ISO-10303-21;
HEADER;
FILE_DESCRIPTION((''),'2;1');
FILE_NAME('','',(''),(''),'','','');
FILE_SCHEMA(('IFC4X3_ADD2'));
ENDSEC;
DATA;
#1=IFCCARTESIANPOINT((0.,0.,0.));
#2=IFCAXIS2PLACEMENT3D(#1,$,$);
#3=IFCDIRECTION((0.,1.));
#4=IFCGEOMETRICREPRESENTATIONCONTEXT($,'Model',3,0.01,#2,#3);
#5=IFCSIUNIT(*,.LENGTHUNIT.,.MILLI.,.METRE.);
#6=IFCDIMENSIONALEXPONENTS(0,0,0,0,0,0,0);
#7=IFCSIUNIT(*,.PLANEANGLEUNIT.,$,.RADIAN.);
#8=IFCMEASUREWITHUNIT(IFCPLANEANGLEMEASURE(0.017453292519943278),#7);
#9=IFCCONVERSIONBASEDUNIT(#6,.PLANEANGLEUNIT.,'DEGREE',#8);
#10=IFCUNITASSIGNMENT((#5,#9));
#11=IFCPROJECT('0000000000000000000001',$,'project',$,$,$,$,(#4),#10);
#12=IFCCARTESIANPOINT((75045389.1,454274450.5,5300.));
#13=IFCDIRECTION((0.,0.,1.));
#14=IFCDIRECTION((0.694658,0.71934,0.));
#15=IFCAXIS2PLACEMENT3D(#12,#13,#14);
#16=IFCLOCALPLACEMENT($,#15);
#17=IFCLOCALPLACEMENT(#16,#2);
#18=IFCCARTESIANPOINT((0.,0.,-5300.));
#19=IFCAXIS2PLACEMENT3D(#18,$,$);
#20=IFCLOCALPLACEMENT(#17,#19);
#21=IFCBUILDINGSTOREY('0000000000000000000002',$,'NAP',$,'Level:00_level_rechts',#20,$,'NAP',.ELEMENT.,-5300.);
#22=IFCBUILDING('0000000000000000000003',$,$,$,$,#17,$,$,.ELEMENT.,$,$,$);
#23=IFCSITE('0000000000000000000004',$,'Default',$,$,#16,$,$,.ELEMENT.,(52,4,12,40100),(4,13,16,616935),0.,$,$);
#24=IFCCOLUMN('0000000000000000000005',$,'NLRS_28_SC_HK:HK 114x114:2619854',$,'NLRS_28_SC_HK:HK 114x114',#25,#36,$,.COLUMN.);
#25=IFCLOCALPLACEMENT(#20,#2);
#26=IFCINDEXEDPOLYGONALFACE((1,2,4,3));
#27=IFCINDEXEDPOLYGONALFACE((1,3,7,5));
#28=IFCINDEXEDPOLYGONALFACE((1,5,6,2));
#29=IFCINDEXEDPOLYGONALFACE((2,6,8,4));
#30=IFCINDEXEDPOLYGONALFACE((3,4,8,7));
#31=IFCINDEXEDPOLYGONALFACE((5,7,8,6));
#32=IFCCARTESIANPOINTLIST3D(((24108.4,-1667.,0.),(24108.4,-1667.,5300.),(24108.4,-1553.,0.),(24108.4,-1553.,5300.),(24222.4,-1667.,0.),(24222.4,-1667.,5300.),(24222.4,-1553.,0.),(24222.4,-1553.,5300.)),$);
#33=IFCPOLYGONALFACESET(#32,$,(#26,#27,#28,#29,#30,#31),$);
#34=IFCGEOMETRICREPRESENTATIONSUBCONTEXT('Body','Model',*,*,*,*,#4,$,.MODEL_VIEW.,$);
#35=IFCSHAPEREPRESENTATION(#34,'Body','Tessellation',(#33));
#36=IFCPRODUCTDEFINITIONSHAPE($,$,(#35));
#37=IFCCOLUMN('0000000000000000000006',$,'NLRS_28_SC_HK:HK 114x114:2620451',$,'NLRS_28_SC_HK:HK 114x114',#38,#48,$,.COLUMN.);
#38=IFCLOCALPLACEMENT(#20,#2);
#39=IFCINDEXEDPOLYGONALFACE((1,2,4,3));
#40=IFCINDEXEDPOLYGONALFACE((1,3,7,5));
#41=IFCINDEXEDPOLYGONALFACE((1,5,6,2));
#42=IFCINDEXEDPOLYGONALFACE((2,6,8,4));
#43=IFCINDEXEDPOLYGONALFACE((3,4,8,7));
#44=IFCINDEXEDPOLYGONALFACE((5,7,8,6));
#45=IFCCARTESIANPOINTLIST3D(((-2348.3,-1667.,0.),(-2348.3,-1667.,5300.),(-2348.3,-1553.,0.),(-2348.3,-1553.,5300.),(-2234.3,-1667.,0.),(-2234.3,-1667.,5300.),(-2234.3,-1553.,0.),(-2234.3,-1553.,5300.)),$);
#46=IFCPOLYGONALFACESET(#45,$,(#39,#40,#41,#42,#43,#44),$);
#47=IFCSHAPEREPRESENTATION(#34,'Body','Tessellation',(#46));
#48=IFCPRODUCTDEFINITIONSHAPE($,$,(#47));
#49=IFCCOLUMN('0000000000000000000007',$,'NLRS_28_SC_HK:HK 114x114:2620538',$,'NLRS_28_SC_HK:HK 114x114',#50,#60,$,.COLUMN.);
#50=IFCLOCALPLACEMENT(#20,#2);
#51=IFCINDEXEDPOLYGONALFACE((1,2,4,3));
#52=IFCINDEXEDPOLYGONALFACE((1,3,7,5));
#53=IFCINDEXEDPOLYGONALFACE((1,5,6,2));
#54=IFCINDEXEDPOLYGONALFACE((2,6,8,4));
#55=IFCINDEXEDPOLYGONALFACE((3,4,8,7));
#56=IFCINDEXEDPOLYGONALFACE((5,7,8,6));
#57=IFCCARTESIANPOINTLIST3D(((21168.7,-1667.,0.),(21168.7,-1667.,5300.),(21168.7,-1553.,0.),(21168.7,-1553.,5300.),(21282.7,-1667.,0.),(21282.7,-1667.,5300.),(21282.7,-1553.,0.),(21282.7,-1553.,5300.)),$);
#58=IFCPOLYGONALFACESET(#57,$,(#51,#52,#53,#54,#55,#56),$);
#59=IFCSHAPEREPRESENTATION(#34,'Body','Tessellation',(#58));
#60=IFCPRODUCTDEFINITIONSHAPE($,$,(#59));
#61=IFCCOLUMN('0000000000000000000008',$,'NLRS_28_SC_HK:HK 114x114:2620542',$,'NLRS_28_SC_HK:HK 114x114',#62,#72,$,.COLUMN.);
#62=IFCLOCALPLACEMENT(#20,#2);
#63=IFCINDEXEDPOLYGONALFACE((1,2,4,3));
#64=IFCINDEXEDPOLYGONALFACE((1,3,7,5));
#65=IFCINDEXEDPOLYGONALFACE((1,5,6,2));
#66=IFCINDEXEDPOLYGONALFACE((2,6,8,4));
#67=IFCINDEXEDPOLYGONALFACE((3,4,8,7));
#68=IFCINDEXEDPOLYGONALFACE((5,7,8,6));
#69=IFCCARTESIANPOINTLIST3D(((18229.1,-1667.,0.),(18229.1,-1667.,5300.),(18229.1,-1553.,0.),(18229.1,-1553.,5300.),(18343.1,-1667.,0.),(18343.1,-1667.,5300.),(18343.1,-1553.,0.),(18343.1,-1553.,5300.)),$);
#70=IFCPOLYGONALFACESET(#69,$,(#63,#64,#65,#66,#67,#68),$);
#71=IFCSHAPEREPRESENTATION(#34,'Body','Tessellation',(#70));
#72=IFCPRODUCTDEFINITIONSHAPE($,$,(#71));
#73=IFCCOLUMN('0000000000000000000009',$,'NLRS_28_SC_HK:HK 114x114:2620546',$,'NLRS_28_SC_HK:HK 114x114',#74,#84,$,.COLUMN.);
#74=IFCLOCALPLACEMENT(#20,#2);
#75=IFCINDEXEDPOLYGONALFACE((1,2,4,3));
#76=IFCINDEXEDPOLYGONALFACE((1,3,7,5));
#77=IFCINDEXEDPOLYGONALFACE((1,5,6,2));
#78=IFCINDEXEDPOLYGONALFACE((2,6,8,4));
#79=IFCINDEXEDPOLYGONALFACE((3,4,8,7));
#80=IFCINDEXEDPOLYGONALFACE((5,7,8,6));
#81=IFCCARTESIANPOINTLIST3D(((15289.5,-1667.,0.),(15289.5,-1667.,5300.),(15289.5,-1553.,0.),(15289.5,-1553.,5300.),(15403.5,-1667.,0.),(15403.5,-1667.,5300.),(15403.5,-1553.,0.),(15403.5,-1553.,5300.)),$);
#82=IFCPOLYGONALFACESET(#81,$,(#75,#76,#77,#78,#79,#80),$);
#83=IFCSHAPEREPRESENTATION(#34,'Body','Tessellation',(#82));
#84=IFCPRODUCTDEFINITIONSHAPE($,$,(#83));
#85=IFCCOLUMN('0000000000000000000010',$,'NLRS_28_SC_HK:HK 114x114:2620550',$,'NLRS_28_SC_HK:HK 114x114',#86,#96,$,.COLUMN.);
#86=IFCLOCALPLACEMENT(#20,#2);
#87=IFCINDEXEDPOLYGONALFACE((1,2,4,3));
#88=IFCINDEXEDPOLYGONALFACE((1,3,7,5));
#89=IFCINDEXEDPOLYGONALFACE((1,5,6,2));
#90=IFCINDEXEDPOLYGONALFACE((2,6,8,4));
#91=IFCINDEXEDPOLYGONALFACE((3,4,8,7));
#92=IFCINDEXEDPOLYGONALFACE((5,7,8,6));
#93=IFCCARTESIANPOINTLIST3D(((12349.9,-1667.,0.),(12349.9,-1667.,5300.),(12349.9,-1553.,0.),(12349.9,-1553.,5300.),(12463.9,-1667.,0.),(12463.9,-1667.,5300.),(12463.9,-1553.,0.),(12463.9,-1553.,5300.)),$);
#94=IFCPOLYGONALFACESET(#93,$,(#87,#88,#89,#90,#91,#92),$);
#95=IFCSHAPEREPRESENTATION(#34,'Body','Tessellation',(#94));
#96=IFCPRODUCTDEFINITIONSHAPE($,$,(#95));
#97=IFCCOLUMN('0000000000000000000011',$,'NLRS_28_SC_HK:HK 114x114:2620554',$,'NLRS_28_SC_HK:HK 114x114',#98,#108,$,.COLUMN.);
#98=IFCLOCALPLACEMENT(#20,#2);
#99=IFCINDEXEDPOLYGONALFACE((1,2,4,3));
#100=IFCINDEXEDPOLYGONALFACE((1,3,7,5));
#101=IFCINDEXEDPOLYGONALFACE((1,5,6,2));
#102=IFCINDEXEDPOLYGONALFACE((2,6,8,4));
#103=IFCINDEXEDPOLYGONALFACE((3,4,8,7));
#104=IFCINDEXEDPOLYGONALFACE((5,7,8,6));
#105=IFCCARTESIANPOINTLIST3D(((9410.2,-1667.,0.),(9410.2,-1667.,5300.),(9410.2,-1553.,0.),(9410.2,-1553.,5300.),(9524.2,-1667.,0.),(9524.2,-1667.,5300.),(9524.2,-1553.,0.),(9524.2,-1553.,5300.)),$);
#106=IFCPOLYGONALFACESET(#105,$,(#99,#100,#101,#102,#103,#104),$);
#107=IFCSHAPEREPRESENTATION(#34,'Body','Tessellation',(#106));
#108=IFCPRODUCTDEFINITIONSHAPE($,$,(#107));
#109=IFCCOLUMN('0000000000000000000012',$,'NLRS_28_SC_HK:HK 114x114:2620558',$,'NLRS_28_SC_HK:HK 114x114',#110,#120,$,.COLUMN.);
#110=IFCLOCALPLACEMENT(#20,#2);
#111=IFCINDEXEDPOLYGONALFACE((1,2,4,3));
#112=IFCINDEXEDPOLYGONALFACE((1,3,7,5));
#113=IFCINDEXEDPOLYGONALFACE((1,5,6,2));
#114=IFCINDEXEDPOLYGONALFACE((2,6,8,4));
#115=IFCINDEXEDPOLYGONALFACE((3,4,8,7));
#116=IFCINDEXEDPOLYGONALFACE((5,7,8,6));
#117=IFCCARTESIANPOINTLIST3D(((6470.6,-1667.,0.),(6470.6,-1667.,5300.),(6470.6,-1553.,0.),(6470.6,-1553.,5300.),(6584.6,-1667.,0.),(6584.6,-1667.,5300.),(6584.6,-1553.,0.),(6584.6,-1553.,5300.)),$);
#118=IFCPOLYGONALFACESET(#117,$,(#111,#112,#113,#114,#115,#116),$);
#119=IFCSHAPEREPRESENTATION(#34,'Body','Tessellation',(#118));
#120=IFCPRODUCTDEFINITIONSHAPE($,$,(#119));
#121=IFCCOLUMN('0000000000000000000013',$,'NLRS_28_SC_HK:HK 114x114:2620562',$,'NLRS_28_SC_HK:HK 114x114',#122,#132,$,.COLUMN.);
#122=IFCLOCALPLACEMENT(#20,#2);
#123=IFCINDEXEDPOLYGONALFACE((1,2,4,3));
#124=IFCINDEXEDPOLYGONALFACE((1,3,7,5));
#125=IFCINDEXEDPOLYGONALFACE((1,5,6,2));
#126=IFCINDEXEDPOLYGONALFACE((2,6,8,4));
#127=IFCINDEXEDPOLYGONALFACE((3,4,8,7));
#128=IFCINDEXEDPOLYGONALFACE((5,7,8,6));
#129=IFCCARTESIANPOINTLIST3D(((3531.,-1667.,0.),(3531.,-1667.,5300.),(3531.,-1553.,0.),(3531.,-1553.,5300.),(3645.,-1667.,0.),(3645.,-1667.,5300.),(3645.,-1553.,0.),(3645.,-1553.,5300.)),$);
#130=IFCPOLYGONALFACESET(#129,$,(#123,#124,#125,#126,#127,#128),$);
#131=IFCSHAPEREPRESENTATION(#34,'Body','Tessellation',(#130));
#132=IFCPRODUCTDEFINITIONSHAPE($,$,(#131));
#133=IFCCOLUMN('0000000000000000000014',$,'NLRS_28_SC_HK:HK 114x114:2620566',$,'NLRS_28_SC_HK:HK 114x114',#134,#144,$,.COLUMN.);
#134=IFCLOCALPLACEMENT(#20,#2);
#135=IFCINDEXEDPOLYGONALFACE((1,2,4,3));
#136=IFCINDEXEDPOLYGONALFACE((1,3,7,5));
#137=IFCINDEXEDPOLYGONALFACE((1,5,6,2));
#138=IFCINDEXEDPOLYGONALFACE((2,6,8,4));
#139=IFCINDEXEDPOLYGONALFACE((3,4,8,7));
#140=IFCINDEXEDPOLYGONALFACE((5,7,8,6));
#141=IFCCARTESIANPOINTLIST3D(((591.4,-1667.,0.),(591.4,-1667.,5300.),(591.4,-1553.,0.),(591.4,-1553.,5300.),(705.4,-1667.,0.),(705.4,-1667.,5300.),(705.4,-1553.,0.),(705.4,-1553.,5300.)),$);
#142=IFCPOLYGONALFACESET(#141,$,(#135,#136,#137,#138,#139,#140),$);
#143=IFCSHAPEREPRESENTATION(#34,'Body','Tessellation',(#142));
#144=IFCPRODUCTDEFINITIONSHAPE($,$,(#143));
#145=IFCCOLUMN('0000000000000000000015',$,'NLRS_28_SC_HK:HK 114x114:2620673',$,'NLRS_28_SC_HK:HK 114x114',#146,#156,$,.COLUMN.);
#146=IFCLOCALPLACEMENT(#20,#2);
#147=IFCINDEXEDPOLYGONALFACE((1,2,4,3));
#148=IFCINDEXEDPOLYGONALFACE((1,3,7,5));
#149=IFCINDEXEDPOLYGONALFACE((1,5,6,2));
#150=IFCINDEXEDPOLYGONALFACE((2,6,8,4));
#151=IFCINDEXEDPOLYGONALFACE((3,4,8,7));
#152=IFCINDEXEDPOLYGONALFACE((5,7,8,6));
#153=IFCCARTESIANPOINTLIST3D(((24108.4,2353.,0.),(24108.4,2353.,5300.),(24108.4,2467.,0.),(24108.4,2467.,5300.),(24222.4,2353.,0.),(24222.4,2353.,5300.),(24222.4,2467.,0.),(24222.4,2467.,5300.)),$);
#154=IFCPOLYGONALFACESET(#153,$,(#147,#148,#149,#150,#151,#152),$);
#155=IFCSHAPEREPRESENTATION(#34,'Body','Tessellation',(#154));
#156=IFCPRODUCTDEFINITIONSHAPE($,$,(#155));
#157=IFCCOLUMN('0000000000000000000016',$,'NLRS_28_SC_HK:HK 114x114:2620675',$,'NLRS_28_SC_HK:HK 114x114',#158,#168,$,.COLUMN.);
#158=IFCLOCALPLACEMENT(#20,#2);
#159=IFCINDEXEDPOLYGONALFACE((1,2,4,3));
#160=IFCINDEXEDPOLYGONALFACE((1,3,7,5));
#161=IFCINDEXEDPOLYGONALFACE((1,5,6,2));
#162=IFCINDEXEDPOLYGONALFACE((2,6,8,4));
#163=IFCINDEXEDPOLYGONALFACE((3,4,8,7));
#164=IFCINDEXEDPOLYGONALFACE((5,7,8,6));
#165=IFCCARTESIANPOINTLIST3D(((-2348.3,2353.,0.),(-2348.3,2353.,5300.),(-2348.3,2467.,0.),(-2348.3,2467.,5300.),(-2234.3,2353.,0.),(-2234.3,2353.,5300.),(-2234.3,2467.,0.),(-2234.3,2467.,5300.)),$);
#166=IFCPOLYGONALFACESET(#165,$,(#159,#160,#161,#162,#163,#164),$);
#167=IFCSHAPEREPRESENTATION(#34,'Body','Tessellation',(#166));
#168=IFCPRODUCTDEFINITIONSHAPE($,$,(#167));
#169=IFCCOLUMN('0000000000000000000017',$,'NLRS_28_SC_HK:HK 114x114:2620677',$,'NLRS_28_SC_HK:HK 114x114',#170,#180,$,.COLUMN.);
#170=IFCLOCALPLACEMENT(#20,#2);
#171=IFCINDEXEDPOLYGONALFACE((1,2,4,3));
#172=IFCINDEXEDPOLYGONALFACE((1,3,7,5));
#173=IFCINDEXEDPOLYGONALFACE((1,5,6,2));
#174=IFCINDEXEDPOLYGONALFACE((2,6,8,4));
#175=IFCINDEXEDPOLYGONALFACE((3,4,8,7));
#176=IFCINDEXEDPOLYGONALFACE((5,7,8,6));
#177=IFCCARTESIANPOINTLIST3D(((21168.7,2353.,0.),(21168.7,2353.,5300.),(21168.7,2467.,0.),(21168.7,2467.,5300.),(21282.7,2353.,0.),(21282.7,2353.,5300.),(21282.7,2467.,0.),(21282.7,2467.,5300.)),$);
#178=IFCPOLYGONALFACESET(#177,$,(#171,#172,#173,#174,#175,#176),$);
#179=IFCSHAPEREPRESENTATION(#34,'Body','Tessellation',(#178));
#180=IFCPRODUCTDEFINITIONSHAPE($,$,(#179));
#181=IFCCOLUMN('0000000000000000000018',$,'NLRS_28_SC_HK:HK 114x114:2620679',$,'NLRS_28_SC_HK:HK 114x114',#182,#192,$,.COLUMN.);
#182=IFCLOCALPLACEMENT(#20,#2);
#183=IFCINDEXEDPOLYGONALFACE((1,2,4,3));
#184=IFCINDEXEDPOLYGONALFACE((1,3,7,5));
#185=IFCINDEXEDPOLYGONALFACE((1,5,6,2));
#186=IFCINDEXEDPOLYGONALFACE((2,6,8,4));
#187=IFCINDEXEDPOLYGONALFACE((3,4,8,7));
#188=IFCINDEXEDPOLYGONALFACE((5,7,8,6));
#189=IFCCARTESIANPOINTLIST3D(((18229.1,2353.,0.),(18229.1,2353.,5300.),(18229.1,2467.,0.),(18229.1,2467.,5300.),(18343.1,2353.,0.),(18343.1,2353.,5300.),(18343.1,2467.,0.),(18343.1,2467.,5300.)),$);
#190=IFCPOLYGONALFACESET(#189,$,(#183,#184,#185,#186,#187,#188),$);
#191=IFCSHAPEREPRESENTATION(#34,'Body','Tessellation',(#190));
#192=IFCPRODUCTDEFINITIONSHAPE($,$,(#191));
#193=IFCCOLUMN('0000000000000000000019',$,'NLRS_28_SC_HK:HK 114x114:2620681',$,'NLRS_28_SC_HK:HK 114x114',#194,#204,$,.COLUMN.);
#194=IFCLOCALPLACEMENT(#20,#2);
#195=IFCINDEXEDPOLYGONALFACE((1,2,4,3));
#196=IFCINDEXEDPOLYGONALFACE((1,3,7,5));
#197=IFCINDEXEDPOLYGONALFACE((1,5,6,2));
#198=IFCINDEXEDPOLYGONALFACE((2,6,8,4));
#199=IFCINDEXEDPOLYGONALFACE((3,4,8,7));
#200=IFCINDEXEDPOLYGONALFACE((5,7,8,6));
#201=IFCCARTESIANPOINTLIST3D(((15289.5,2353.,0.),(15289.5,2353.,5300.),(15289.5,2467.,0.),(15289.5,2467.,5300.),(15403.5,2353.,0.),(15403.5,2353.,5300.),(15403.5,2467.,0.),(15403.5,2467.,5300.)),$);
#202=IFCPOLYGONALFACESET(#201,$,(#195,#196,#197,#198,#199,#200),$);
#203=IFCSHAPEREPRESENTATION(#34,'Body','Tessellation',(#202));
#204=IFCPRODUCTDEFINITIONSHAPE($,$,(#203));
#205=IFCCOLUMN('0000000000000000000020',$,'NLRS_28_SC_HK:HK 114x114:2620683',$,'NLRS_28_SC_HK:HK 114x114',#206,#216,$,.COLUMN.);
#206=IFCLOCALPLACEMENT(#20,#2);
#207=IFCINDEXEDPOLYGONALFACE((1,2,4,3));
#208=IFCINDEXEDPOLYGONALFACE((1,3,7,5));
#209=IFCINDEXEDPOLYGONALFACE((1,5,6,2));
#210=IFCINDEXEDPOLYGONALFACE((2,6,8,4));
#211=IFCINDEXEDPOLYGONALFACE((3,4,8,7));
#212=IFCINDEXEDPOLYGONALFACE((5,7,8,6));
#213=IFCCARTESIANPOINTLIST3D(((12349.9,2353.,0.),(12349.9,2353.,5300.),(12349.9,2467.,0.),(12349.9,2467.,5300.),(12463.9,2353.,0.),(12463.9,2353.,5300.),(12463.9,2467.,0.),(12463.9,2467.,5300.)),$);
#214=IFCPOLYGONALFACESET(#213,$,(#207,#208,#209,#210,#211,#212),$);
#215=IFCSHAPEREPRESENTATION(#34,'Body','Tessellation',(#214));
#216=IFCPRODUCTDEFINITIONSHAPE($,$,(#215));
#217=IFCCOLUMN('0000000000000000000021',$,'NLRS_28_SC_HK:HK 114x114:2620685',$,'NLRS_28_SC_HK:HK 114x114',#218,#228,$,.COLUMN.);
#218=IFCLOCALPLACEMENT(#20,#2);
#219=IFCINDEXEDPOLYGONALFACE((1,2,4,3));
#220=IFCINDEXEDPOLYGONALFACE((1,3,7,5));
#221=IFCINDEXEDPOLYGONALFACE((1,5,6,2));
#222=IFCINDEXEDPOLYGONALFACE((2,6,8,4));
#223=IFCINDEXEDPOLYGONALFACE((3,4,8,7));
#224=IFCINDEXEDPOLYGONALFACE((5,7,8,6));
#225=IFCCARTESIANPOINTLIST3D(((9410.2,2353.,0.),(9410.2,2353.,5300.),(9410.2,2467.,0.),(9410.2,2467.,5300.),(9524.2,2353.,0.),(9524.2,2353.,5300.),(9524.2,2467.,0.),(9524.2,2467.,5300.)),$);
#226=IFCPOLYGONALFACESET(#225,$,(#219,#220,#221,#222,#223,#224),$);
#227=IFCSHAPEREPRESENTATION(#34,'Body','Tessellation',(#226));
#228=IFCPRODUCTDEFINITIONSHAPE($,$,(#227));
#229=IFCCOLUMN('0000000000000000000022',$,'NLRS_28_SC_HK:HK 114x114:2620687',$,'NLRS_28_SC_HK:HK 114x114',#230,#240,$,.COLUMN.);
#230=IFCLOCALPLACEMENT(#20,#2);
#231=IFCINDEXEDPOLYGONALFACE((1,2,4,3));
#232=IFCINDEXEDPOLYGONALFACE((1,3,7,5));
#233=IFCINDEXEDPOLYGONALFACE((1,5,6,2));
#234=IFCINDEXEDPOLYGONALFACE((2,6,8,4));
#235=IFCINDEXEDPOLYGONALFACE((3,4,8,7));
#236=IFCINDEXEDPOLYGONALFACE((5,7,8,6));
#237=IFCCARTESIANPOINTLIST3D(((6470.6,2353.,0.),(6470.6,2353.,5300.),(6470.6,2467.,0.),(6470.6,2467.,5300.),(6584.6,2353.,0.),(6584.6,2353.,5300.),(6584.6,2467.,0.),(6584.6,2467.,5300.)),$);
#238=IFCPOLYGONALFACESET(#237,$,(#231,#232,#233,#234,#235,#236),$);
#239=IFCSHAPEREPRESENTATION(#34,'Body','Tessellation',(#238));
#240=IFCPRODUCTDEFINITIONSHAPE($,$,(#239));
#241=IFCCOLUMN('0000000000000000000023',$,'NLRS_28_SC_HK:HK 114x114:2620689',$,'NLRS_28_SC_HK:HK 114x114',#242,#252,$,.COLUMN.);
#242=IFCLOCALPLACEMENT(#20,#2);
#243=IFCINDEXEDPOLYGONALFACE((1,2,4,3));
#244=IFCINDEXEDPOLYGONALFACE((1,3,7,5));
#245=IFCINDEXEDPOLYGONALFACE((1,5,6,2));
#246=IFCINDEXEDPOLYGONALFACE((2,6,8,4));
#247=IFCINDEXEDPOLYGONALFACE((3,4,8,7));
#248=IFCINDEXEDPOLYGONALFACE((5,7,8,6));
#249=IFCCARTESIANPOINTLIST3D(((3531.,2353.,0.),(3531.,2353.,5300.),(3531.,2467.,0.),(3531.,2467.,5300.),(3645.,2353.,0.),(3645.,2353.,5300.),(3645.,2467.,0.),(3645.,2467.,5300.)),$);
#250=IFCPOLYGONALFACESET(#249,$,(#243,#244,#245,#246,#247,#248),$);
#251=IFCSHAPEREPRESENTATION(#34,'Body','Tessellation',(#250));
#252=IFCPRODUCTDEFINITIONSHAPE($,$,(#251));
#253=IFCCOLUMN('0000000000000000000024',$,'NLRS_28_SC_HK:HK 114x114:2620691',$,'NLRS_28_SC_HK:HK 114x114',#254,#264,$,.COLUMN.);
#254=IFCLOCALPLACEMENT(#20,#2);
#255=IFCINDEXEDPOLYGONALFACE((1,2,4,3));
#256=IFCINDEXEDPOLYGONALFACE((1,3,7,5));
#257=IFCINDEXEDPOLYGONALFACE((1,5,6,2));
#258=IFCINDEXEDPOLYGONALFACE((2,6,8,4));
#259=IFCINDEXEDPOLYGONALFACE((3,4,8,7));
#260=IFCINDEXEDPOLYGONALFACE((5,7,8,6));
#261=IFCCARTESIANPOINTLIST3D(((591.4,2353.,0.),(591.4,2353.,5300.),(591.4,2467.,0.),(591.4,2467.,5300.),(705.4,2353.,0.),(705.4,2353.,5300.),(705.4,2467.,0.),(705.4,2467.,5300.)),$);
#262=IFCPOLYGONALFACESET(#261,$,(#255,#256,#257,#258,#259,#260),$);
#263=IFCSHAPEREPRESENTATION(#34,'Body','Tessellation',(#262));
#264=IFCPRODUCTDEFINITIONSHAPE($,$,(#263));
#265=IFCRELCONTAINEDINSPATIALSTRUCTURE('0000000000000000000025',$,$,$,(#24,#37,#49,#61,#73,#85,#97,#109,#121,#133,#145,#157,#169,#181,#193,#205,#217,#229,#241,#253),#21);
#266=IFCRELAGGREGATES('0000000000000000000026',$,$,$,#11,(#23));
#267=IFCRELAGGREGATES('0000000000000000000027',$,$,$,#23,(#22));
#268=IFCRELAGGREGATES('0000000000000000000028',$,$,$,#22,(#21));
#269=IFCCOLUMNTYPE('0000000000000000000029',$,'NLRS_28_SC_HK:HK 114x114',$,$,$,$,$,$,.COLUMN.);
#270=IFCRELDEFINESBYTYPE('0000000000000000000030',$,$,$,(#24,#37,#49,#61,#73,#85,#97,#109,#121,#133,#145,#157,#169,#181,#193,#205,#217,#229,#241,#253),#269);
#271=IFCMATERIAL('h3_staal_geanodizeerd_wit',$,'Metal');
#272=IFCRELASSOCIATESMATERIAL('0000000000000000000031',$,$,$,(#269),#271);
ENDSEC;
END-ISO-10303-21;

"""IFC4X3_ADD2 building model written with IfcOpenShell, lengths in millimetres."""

from ifc_helpers import new_model, entity, si_unit, converted_unit, direction, frame, origin, origin_2d_with_axis, place, context, subcontext, project, spatial, rectangle, extrude, source, transform, mapped, material, material_profile, profile_set, type_object, type_shapes, element, save


model = new_model("IFC4X3_ADD2")

# Units and contexts
model_context = context("Model", 3, precision=0.01, world=origin(), true_north=direction((0.0, 1.0)))
body_context = subcontext(model_context, "Body", "Model", "MODEL_VIEW")
ifc_project = project(units=[si_unit("LENGTHUNIT", "METRE", prefix="MILLI"), converted_unit("PLANEANGLEUNIT", "DEGREE", entity("IfcPlaneAngleMeasure", 0.017453292519943278), si_unit("PLANEANGLEUNIT", "RADIAN"), dimensions=[0, 0, 0, 0, 0, 0, 0])], contexts=[model_context])

# Site, building, storey
site_placement = place(None, frame((75045389.1, 454274450.5, 5300.0), z_axis=(0.0, 0.0, 1.0), x_axis=(0.694658, 0.71934, 0.0)))
site = spatial("IfcSite", under=ifc_project, at=site_placement, Name="Default", CompositionType="ELEMENT", RefLatitude=(52, 4, 12, 40100), RefLongitude=(4, 13, 16, 616935), RefElevation=0.0)
building_placement = place(site_placement, origin())
building = spatial("IfcBuilding", under=site, at=building_placement, CompositionType="ELEMENT")
storey_placement = place(building_placement, frame((0.0, 0.0, -5300.0)))
storey = spatial("IfcBuildingStorey", under=building, at=storey_placement, Name="NAP", ObjectType="Level:00_level_rechts", LongName="NAP", CompositionType="ELEMENT", Elevation=-5300.0)

# Columns
ifc_material = material(Name="h3_staal_geanodizeerd_wit", Category="Metal")
ifc_material_profile = material_profile(ifc_material, rectangle(XDim=114.0, YDim=114.0, at=origin_2d_with_axis()), Name="HK 114x114")
ifc_profile_set = profile_set([ifc_material_profile], Name="HK 114x114")
column_type = type_object("IfcColumnType", Name="NLRS_28_SC_HK:HK 114x114", PredefinedType="COLUMN", material=ifc_profile_set)
shared_shape = source(origin(), body_context, "Body", "SweptSolid", [
    extrude(rectangle(XDim=114.0, YDim=114.0, at=origin_2d_with_axis()), frame((0.0, 0.0, -5300.0), z_axis=(0.0, 0.0, 1.0), x_axis=(-1.0, 0.0, 0.0)), (0.0, 0.0, 1.0), 5300.0),
])
type_shapes(column_type, [shared_shape])
for number, where, name in (
    (1, (24165.4, -1610.0, 5300.0), "NLRS_28_SC_HK:HK 114x114:2619854"),
    (2, (-2291.3, -1610.0, 5300.0), "NLRS_28_SC_HK:HK 114x114:2620451"),
    (3, (21225.7, -1610.0, 5300.0), "NLRS_28_SC_HK:HK 114x114:2620538"),
    (4, (18286.1, -1610.0, 5300.0), "NLRS_28_SC_HK:HK 114x114:2620542"),
    (5, (15346.5, -1610.0, 5300.0), "NLRS_28_SC_HK:HK 114x114:2620546"),
    (6, (12406.9, -1610.0, 5300.0), "NLRS_28_SC_HK:HK 114x114:2620550"),
    (7, (9467.2, -1610.0, 5300.0), "NLRS_28_SC_HK:HK 114x114:2620554"),
    (8, (6527.6, -1610.0, 5300.0), "NLRS_28_SC_HK:HK 114x114:2620558"),
    (9, (3588.0, -1610.0, 5300.0), "NLRS_28_SC_HK:HK 114x114:2620562"),
    (10, (648.4, -1610.0, 5300.0), "NLRS_28_SC_HK:HK 114x114:2620566"),
    (11, (24165.4, 2410.0, 5300.0), "NLRS_28_SC_HK:HK 114x114:2620673"),
    (12, (-2291.3, 2410.0, 5300.0), "NLRS_28_SC_HK:HK 114x114:2620675"),
    (13, (21225.7, 2410.0, 5300.0), "NLRS_28_SC_HK:HK 114x114:2620677"),
    (14, (18286.1, 2410.0, 5300.0), "NLRS_28_SC_HK:HK 114x114:2620679"),
    (15, (15346.5, 2410.0, 5300.0), "NLRS_28_SC_HK:HK 114x114:2620681"),
    (16, (12406.9, 2410.0, 5300.0), "NLRS_28_SC_HK:HK 114x114:2620683"),
    (17, (9467.2, 2410.0, 5300.0), "NLRS_28_SC_HK:HK 114x114:2620685"),
    (18, (6527.6, 2410.0, 5300.0), "NLRS_28_SC_HK:HK 114x114:2620687"),
    (19, (3588.0, 2410.0, 5300.0), "NLRS_28_SC_HK:HK 114x114:2620689"),
    (20, (648.4, 2410.0, 5300.0), "NLRS_28_SC_HK:HK 114x114:2620691"),
):
    element("IfcColumn", number, at=place(storey_placement, frame(where)), inside=storey, type_object=column_type, Name=name, ObjectType="NLRS_28_SC_HK:HK 114x114", PredefinedType="COLUMN", context=body_context, shape_type="MappedRepresentation", body=[
        mapped(shared_shape, transform((0.0, 0.0, 0.0), scale=1.0)),
    ])

save(model, "model.ifc")
